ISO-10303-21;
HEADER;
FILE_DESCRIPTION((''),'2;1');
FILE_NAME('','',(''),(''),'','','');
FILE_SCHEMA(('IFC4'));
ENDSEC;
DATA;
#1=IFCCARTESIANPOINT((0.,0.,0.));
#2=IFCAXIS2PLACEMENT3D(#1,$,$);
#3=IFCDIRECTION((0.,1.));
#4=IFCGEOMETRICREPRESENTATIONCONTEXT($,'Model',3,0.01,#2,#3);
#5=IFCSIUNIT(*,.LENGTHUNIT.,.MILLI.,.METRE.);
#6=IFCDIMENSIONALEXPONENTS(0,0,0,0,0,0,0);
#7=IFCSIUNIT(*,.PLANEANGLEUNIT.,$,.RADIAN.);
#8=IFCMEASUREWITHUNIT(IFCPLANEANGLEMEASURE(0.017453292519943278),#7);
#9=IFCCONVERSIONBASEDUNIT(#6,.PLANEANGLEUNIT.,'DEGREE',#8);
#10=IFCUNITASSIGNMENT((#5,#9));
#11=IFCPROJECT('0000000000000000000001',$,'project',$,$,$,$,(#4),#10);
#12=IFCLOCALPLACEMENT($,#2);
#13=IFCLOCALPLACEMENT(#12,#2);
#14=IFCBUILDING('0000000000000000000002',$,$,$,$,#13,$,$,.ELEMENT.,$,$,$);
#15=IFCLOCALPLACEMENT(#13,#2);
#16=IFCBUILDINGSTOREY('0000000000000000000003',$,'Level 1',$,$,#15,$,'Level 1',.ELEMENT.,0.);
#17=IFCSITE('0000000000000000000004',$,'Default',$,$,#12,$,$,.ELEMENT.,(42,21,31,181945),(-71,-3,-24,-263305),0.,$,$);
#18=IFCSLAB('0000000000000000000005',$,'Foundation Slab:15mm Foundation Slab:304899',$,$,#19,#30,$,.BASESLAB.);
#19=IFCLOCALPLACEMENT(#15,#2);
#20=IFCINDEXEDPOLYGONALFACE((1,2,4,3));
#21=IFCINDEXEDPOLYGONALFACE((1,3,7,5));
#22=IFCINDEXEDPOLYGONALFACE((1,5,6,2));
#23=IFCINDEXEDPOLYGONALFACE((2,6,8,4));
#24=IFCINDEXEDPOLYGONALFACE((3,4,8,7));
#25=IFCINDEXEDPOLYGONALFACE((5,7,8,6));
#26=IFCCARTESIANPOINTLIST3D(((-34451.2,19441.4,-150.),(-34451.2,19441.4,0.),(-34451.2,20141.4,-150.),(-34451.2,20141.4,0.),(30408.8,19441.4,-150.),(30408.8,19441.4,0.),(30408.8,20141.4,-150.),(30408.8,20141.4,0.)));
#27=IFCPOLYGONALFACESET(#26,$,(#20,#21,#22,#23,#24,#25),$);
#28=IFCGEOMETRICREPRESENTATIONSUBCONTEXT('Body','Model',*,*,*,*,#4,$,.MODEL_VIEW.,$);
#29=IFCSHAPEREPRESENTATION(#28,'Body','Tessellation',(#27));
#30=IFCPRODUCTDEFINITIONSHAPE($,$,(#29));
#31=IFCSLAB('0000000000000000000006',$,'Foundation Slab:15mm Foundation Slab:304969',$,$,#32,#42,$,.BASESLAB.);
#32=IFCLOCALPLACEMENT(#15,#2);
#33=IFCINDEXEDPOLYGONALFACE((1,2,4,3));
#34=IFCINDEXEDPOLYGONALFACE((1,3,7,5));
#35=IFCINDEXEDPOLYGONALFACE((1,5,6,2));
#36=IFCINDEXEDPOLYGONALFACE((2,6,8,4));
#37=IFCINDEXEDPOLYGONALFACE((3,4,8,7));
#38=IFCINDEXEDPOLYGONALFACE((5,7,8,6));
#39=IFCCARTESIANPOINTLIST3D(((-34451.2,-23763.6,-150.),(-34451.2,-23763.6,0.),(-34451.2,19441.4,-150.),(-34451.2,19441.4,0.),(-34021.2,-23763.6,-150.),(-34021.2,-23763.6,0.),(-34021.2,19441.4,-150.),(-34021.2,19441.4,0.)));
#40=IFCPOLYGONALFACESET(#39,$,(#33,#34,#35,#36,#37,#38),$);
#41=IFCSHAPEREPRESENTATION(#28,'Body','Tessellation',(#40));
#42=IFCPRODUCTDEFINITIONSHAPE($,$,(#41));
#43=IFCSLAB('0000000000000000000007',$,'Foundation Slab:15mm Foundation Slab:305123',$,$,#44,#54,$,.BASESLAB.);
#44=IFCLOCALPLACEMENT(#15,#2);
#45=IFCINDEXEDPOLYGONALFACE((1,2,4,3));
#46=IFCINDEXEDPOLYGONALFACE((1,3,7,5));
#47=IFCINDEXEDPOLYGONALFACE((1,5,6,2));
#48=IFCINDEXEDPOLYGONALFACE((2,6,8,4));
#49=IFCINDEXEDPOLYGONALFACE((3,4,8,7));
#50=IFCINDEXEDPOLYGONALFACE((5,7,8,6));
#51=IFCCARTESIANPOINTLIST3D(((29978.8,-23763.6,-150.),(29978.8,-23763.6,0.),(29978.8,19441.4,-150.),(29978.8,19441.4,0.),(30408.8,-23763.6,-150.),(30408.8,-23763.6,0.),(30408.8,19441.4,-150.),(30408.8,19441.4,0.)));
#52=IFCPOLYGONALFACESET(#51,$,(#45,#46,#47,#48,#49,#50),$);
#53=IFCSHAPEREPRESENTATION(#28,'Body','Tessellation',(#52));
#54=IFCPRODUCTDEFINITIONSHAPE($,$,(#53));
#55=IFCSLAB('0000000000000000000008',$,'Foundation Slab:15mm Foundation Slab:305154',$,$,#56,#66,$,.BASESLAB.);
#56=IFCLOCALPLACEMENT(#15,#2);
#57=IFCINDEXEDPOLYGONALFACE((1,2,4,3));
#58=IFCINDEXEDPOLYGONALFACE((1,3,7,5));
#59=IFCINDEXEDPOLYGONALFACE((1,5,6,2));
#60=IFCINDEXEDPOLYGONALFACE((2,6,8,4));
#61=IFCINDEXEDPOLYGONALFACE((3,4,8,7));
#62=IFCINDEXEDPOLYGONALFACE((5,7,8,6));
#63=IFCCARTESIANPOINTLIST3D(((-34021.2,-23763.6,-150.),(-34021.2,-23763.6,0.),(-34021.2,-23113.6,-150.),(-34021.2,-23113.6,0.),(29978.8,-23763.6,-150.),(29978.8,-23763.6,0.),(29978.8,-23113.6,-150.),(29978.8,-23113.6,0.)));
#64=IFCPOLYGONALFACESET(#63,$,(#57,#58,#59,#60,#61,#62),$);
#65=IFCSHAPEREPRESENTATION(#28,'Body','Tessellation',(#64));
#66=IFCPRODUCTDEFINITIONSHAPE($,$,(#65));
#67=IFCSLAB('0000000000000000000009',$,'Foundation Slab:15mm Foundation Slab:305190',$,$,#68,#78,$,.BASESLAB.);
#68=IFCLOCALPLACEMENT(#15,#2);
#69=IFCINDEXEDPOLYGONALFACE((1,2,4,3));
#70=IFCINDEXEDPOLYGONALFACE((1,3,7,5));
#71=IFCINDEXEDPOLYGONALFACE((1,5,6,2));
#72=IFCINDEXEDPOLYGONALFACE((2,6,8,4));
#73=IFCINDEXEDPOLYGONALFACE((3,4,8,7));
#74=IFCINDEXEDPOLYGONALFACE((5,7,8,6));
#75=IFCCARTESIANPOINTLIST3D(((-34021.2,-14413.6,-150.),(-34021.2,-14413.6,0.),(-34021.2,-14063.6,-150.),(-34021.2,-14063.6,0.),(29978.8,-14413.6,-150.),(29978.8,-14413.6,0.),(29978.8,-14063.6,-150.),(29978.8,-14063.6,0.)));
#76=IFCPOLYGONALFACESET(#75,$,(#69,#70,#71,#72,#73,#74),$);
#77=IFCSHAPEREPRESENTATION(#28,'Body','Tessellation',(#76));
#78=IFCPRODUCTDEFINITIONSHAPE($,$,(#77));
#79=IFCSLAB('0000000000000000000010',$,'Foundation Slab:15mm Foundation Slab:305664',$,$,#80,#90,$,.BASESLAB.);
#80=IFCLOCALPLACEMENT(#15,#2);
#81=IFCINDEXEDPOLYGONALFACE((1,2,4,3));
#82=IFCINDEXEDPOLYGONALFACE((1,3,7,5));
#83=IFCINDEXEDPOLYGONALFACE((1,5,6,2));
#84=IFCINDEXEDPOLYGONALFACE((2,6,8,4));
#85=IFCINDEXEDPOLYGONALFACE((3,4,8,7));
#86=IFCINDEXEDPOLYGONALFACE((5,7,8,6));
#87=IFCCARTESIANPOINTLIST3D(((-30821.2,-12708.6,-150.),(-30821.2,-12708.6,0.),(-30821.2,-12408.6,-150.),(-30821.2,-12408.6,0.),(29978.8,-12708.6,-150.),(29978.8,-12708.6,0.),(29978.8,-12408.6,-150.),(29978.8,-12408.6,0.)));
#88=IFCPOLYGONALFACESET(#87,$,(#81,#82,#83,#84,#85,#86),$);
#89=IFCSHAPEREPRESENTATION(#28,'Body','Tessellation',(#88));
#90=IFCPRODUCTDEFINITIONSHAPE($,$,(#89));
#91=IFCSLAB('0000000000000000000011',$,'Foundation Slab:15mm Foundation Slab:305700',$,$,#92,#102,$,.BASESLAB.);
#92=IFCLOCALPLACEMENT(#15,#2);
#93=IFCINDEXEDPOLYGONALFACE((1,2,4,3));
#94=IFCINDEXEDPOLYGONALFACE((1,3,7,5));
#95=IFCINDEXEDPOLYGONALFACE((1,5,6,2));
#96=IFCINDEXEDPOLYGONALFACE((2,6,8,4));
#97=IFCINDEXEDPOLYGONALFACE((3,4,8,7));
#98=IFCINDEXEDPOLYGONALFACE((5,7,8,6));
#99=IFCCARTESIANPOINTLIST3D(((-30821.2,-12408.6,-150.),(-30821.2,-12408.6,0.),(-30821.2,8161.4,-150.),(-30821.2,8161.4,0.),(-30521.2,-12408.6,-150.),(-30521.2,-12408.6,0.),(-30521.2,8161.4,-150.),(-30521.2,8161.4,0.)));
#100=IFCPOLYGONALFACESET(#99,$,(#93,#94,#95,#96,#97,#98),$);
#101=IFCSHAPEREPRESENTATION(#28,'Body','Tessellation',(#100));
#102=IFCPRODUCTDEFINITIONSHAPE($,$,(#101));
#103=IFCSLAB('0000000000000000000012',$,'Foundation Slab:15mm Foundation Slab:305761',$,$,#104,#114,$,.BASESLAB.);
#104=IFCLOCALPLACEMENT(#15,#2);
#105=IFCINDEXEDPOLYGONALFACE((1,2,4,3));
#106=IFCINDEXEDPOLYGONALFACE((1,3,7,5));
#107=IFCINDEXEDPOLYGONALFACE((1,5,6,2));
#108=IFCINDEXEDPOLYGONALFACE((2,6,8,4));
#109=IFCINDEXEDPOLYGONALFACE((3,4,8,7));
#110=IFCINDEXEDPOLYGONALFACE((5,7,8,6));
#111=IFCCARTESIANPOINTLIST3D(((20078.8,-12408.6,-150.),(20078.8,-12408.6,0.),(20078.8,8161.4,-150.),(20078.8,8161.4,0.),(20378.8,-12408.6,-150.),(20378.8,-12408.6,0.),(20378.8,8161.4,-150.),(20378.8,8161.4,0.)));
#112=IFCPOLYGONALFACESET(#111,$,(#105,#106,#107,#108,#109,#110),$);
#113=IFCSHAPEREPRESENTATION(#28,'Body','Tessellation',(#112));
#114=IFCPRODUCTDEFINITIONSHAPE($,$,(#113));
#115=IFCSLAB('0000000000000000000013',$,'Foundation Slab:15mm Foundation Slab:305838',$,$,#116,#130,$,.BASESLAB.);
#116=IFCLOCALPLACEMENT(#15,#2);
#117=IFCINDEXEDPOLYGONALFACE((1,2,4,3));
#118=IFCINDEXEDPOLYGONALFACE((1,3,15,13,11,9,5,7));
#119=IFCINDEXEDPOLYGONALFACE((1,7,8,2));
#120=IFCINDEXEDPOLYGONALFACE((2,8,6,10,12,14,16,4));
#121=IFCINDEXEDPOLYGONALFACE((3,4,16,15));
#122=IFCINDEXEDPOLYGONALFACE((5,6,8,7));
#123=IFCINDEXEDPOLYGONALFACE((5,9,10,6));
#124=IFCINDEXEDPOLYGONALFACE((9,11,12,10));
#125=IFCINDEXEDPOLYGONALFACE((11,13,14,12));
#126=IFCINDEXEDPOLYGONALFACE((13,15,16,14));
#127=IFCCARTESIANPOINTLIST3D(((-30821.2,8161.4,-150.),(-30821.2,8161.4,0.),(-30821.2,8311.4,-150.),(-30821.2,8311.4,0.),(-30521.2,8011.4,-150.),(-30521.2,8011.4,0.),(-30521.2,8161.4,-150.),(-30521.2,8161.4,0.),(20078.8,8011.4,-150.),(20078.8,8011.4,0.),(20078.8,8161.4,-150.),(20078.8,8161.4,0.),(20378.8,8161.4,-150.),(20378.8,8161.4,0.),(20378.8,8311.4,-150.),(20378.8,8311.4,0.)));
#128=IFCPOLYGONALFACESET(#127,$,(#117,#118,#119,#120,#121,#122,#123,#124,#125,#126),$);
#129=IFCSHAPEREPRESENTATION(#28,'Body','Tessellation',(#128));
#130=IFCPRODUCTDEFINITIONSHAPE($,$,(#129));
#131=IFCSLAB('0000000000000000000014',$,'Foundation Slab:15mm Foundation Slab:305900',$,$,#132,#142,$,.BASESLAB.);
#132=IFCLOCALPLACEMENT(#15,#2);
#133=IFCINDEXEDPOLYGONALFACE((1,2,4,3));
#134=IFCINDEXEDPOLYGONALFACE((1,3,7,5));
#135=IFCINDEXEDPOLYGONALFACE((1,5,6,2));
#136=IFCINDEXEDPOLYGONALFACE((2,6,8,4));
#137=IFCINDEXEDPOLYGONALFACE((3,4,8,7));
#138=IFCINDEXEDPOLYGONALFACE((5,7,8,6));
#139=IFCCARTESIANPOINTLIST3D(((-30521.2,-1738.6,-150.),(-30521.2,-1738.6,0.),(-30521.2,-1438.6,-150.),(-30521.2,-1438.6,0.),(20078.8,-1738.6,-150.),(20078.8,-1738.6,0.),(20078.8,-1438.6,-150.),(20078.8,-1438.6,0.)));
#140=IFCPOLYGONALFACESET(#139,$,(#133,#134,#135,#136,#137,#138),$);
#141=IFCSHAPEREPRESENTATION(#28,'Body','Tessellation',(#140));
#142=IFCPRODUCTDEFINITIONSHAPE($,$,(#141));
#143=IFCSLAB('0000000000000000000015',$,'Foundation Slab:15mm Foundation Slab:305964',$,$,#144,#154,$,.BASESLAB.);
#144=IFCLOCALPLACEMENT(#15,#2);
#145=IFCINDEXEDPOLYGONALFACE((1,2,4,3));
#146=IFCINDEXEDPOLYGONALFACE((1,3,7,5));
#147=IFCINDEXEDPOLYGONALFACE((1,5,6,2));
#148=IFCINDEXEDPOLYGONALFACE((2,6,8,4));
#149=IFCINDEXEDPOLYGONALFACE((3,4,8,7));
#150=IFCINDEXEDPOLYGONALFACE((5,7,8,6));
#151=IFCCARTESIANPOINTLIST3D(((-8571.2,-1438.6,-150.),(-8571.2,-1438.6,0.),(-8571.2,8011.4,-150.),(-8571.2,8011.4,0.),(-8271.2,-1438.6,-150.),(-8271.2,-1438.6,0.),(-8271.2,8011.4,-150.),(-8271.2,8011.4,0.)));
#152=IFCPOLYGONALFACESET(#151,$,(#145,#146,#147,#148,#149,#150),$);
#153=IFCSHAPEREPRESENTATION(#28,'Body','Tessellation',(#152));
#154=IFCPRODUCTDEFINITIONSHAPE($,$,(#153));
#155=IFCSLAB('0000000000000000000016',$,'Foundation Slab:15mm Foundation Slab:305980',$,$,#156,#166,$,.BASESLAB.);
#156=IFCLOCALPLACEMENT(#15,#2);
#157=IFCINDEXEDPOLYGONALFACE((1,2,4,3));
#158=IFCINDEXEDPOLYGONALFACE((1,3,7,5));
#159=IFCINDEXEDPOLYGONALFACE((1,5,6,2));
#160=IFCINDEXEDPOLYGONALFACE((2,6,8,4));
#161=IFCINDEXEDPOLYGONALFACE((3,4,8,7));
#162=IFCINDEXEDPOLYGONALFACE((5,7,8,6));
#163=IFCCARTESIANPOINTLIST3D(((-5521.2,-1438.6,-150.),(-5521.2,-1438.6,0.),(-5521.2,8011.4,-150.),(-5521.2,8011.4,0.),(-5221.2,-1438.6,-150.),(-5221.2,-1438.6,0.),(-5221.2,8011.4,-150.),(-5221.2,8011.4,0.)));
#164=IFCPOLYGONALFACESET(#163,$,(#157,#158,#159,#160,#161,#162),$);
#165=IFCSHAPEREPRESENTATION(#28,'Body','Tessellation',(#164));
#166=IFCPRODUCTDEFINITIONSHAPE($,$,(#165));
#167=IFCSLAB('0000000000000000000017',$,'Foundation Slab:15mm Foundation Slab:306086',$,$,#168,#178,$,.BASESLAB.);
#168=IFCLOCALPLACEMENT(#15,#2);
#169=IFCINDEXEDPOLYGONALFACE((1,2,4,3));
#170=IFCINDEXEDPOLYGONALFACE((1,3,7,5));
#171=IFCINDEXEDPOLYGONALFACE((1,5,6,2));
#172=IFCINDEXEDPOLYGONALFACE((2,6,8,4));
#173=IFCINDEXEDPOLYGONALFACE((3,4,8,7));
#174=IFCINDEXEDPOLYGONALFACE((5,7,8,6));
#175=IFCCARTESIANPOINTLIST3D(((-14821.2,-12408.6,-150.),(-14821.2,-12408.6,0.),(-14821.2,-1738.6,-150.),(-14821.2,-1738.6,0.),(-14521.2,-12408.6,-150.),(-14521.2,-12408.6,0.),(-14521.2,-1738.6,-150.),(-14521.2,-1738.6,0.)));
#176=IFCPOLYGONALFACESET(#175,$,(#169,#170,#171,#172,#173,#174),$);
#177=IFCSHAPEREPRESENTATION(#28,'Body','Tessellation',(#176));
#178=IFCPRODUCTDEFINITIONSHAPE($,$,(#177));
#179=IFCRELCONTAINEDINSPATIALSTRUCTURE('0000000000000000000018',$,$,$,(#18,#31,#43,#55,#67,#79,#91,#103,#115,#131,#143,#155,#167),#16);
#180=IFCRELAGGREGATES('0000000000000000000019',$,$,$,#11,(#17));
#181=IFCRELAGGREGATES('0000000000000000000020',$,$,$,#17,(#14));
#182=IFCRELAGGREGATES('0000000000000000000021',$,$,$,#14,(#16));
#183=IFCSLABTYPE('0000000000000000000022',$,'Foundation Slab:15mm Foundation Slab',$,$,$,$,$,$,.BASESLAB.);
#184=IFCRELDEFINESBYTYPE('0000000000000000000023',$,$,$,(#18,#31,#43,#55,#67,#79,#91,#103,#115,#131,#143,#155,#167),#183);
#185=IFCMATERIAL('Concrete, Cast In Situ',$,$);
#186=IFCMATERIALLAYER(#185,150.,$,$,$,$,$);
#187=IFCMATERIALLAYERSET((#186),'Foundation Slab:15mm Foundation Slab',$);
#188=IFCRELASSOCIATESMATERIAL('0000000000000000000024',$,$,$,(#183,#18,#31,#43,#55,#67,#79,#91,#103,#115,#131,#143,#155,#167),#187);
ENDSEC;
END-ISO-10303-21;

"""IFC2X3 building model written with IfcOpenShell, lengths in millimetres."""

from ifc_helpers import new_model, entity, si_unit, converted_unit, direction, frame, frame_2d, origin, origin_2d_with_axis, place, context, subcontext, project, spatial, polyline, rectangle, outline, extrude, material, layer, layer_set, layer_usage, type_object, element, save


model = new_model("IFC2X3")

# Units and contexts
model_context = context("Model", 3, precision=0.01, world=origin(), true_north=direction((0.0, 1.0)))
body_context = subcontext(model_context, "Body", "Model", "MODEL_VIEW")
ifc_project = project(units=[si_unit("LENGTHUNIT", "METRE", prefix="MILLI"), converted_unit("PLANEANGLEUNIT", "DEGREE", entity("IfcPlaneAngleMeasure", 0.017453292519943278), si_unit("PLANEANGLEUNIT", "RADIAN"), dimensions=[0, 0, 0, 0, 0, 0, 0])], contexts=[model_context])

# Site, building, storey
site_placement = place(None, origin())
site = spatial("IfcSite", under=ifc_project, at=site_placement, Name="Default", CompositionType="ELEMENT", RefLatitude=(42, 21, 31, 181945), RefLongitude=(-71, -3, -24, -263305), RefElevation=0.0)
building_placement = place(site_placement, origin())
building = spatial("IfcBuilding", under=site, at=building_placement, CompositionType="ELEMENT")
storey_placement = place(building_placement, origin())
storey = spatial("IfcBuildingStorey", under=building, at=storey_placement, Name="Level 1", LongName="Level 1", CompositionType="ELEMENT", Elevation=0.0)

# Slabs
ifc_material = material(Name="Concrete, Cast In Situ")
ifc_layer = layer(ifc_material, 150.0)
ifc_layer_set = layer_set([ifc_layer], Name="Foundation Slab:15mm Foundation Slab")
ifc_layer_usage_1 = layer_usage(ifc_layer_set, "AXIS3", "POSITIVE", 0.0)
slab_type = type_object("IfcSlabType", Name="Foundation Slab:15mm Foundation Slab", PredefinedType="BASESLAB", material=ifc_layer_set)
slab_1_placement = place(storey_placement, origin())
element("IfcSlab", 1, at=slab_1_placement, inside=storey, type_object=slab_type, material=ifc_layer_usage_1, Name="Foundation Slab:15mm Foundation Slab:304899", PredefinedType="BASESLAB", context=body_context, shape_type="SweptSolid", body=[
    extrude(rectangle(XDim=700.0, YDim=64860.0, at=frame_2d((0.0, 0.0), x_axis=(1.0, 0.0))), frame((-2021.2, 19791.4, 0.0), z_axis=(0.0, 0.0, -1.0), x_axis=(0.0, 1.0, 0.0)), (0.0, 0.0, 1.0), 150.0),
])
ifc_layer_usage_2 = layer_usage(ifc_layer_set, "AXIS3", "POSITIVE", 0.0)
slab_2_placement = place(storey_placement, origin())
element("IfcSlab", 2, at=slab_2_placement, inside=storey, type_object=slab_type, material=ifc_layer_usage_2, Name="Foundation Slab:15mm Foundation Slab:304969", PredefinedType="BASESLAB", context=body_context, shape_type="SweptSolid", body=[
    extrude(rectangle(XDim=43205.0, YDim=430.0, at=frame_2d((0.0, 0.0), x_axis=(1.0, 0.0))), frame((-34236.2, -2161.1, 0.0), z_axis=(0.0, 0.0, -1.0), x_axis=(0.0, 1.0, 0.0)), (0.0, 0.0, 1.0), 150.0),
])
ifc_layer_usage_3 = layer_usage(ifc_layer_set, "AXIS3", "POSITIVE", 0.0)
slab_3_placement = place(storey_placement, origin())
element("IfcSlab", 3, at=slab_3_placement, inside=storey, type_object=slab_type, material=ifc_layer_usage_3, Name="Foundation Slab:15mm Foundation Slab:305123", PredefinedType="BASESLAB", context=body_context, shape_type="SweptSolid", body=[
    extrude(rectangle(XDim=43205.0, YDim=430.0, at=frame_2d((0.0, 0.0), x_axis=(1.0, 0.0))), frame((30193.8, -2161.1, 0.0), z_axis=(0.0, 0.0, -1.0), x_axis=(0.0, 1.0, 0.0)), (0.0, 0.0, 1.0), 150.0),
])
ifc_layer_usage_4 = layer_usage(ifc_layer_set, "AXIS3", "POSITIVE", 0.0)
slab_4_placement = place(storey_placement, origin())
element("IfcSlab", 4, at=slab_4_placement, inside=storey, type_object=slab_type, material=ifc_layer_usage_4, Name="Foundation Slab:15mm Foundation Slab:305154", PredefinedType="BASESLAB", context=body_context, shape_type="SweptSolid", body=[
    extrude(rectangle(XDim=650.0, YDim=64000.0, at=origin_2d_with_axis()), frame((-2021.2, -23438.6, 0.0), z_axis=(0.0, 0.0, -1.0), x_axis=(0.0, 1.0, 0.0)), (0.0, 0.0, 1.0), 150.0),
])
ifc_layer_usage_5 = layer_usage(ifc_layer_set, "AXIS3", "POSITIVE", 0.0)
slab_5_placement = place(storey_placement, origin())
element("IfcSlab", 5, at=slab_5_placement, inside=storey, type_object=slab_type, material=ifc_layer_usage_5, Name="Foundation Slab:15mm Foundation Slab:305190", PredefinedType="BASESLAB", context=body_context, shape_type="SweptSolid", body=[
    extrude(rectangle(XDim=350.0, YDim=64000.0, at=frame_2d((0.0, 0.0), x_axis=(1.0, 0.0))), frame((-2021.2, -14238.6, 0.0), z_axis=(0.0, 0.0, -1.0), x_axis=(0.0, 1.0, 0.0)), (0.0, 0.0, 1.0), 150.0),
])
ifc_layer_usage_6 = layer_usage(ifc_layer_set, "AXIS3", "POSITIVE", 0.0)
slab_6_placement = place(storey_placement, origin())
element("IfcSlab", 6, at=slab_6_placement, inside=storey, type_object=slab_type, material=ifc_layer_usage_6, Name="Foundation Slab:15mm Foundation Slab:305664", PredefinedType="BASESLAB", context=body_context, shape_type="SweptSolid", body=[
    extrude(rectangle(XDim=300.0, YDim=60800.0, at=frame_2d((0.0, 0.0), x_axis=(1.0, 0.0))), frame((-421.2, -12558.6, 0.0), z_axis=(0.0, 0.0, -1.0), x_axis=(0.0, 1.0, 0.0)), (0.0, 0.0, 1.0), 150.0),
])
ifc_layer_usage_7 = layer_usage(ifc_layer_set, "AXIS3", "POSITIVE", 0.0)
slab_7_placement = place(storey_placement, origin())
element("IfcSlab", 7, at=slab_7_placement, inside=storey, type_object=slab_type, material=ifc_layer_usage_7, Name="Foundation Slab:15mm Foundation Slab:305700", PredefinedType="BASESLAB", context=body_context, shape_type="SweptSolid", body=[
    extrude(rectangle(XDim=20570.0, YDim=300.0, at=frame_2d((0.0, 0.0), x_axis=(1.0, 0.0))), frame((-30671.2, -2123.6, 0.0), z_axis=(0.0, 0.0, -1.0), x_axis=(0.0, 1.0, 0.0)), (0.0, 0.0, 1.0), 150.0),
])
ifc_layer_usage_8 = layer_usage(ifc_layer_set, "AXIS3", "POSITIVE", 0.0)
slab_8_placement = place(storey_placement, origin())
element("IfcSlab", 8, at=slab_8_placement, inside=storey, type_object=slab_type, material=ifc_layer_usage_8, Name="Foundation Slab:15mm Foundation Slab:305761", PredefinedType="BASESLAB", context=body_context, shape_type="SweptSolid", body=[
    extrude(rectangle(XDim=20570.0, YDim=300.0, at=frame_2d((0.0, 0.0), x_axis=(1.0, 0.0))), frame((20228.8, -2123.6, 0.0), z_axis=(0.0, 0.0, -1.0), x_axis=(0.0, 1.0, 0.0)), (0.0, 0.0, 1.0), 150.0),
])
ifc_layer_usage_9 = layer_usage(ifc_layer_set, "AXIS3", "POSITIVE", 0.0)
slab_9_placement = place(storey_placement, origin())
element("IfcSlab", 9, at=slab_9_placement, inside=storey, type_object=slab_type, material=ifc_layer_usage_9, Name="Foundation Slab:15mm Foundation Slab:305838", PredefinedType="BASESLAB", context=body_context, shape_type="SweptSolid", body=[
    extrude(outline(polyline([(0.0, -25600.0), (150.0, -25600.0), (150.0, 25600.0), (0.0, 25600.0), (0.0, 25300.0), (-150.0, 25300.0), (-150.0, -25300.0), (0.0, -25300.0), (0.0, -25600.0)])), frame((-5221.2, 8161.4, 0.0), z_axis=(0.0, 0.0, -1.0), x_axis=(0.0, 1.0, 0.0)), (0.0, 0.0, 1.0), 150.0),
])
ifc_layer_usage_10 = layer_usage(ifc_layer_set, "AXIS3", "POSITIVE", 0.0)
slab_10_placement = place(storey_placement, origin())
element("IfcSlab", 10, at=slab_10_placement, inside=storey, type_object=slab_type, material=ifc_layer_usage_10, Name="Foundation Slab:15mm Foundation Slab:305900", PredefinedType="BASESLAB", context=body_context, shape_type="SweptSolid", body=[
    extrude(rectangle(XDim=300.0, YDim=50600.0, at=origin_2d_with_axis()), frame((-5221.2, -1588.6, 0.0), z_axis=(0.0, 0.0, -1.0), x_axis=(0.0, 1.0, 0.0)), (0.0, 0.0, 1.0), 150.0),
])
ifc_layer_usage_11 = layer_usage(ifc_layer_set, "AXIS3", "POSITIVE", 0.0)
slab_11_placement = place(storey_placement, origin())
element("IfcSlab", 11, at=slab_11_placement, inside=storey, type_object=slab_type, material=ifc_layer_usage_11, Name="Foundation Slab:15mm Foundation Slab:305964", PredefinedType="BASESLAB", context=body_context, shape_type="SweptSolid", body=[
    extrude(rectangle(XDim=9450.0, YDim=300.0, at=frame_2d((0.0, 0.0), x_axis=(1.0, 0.0))), frame((-8421.2, 3286.4, 0.0), z_axis=(0.0, 0.0, -1.0), x_axis=(0.0, 1.0, 0.0)), (0.0, 0.0, 1.0), 150.0),
])
ifc_layer_usage_12 = layer_usage(ifc_layer_set, "AXIS3", "POSITIVE", 0.0)
slab_12_placement = place(storey_placement, origin())
element("IfcSlab", 12, at=slab_12_placement, inside=storey, type_object=slab_type, material=ifc_layer_usage_12, Name="Foundation Slab:15mm Foundation Slab:305980", PredefinedType="BASESLAB", context=body_context, shape_type="SweptSolid", body=[
    extrude(rectangle(XDim=9450.0, YDim=300.0, at=frame_2d((0.0, 0.0), x_axis=(1.0, 0.0))), frame((-5371.2, 3286.4, 0.0), z_axis=(0.0, 0.0, -1.0), x_axis=(0.0, 1.0, 0.0)), (0.0, 0.0, 1.0), 150.0),
])
ifc_layer_usage_13 = layer_usage(ifc_layer_set, "AXIS3", "POSITIVE", 0.0)
slab_13_placement = place(storey_placement, origin())
element("IfcSlab", 13, at=slab_13_placement, inside=storey, type_object=slab_type, material=ifc_layer_usage_13, Name="Foundation Slab:15mm Foundation Slab:306086", PredefinedType="BASESLAB", context=body_context, shape_type="SweptSolid", body=[
    extrude(rectangle(XDim=10670.0, YDim=300.0, at=origin_2d_with_axis()), frame((-14671.2, -7073.6, 0.0), z_axis=(0.0, 0.0, -1.0), x_axis=(0.0, 1.0, 0.0)), (0.0, 0.0, 1.0), 150.0),
])

save(model, "model.ifc")
